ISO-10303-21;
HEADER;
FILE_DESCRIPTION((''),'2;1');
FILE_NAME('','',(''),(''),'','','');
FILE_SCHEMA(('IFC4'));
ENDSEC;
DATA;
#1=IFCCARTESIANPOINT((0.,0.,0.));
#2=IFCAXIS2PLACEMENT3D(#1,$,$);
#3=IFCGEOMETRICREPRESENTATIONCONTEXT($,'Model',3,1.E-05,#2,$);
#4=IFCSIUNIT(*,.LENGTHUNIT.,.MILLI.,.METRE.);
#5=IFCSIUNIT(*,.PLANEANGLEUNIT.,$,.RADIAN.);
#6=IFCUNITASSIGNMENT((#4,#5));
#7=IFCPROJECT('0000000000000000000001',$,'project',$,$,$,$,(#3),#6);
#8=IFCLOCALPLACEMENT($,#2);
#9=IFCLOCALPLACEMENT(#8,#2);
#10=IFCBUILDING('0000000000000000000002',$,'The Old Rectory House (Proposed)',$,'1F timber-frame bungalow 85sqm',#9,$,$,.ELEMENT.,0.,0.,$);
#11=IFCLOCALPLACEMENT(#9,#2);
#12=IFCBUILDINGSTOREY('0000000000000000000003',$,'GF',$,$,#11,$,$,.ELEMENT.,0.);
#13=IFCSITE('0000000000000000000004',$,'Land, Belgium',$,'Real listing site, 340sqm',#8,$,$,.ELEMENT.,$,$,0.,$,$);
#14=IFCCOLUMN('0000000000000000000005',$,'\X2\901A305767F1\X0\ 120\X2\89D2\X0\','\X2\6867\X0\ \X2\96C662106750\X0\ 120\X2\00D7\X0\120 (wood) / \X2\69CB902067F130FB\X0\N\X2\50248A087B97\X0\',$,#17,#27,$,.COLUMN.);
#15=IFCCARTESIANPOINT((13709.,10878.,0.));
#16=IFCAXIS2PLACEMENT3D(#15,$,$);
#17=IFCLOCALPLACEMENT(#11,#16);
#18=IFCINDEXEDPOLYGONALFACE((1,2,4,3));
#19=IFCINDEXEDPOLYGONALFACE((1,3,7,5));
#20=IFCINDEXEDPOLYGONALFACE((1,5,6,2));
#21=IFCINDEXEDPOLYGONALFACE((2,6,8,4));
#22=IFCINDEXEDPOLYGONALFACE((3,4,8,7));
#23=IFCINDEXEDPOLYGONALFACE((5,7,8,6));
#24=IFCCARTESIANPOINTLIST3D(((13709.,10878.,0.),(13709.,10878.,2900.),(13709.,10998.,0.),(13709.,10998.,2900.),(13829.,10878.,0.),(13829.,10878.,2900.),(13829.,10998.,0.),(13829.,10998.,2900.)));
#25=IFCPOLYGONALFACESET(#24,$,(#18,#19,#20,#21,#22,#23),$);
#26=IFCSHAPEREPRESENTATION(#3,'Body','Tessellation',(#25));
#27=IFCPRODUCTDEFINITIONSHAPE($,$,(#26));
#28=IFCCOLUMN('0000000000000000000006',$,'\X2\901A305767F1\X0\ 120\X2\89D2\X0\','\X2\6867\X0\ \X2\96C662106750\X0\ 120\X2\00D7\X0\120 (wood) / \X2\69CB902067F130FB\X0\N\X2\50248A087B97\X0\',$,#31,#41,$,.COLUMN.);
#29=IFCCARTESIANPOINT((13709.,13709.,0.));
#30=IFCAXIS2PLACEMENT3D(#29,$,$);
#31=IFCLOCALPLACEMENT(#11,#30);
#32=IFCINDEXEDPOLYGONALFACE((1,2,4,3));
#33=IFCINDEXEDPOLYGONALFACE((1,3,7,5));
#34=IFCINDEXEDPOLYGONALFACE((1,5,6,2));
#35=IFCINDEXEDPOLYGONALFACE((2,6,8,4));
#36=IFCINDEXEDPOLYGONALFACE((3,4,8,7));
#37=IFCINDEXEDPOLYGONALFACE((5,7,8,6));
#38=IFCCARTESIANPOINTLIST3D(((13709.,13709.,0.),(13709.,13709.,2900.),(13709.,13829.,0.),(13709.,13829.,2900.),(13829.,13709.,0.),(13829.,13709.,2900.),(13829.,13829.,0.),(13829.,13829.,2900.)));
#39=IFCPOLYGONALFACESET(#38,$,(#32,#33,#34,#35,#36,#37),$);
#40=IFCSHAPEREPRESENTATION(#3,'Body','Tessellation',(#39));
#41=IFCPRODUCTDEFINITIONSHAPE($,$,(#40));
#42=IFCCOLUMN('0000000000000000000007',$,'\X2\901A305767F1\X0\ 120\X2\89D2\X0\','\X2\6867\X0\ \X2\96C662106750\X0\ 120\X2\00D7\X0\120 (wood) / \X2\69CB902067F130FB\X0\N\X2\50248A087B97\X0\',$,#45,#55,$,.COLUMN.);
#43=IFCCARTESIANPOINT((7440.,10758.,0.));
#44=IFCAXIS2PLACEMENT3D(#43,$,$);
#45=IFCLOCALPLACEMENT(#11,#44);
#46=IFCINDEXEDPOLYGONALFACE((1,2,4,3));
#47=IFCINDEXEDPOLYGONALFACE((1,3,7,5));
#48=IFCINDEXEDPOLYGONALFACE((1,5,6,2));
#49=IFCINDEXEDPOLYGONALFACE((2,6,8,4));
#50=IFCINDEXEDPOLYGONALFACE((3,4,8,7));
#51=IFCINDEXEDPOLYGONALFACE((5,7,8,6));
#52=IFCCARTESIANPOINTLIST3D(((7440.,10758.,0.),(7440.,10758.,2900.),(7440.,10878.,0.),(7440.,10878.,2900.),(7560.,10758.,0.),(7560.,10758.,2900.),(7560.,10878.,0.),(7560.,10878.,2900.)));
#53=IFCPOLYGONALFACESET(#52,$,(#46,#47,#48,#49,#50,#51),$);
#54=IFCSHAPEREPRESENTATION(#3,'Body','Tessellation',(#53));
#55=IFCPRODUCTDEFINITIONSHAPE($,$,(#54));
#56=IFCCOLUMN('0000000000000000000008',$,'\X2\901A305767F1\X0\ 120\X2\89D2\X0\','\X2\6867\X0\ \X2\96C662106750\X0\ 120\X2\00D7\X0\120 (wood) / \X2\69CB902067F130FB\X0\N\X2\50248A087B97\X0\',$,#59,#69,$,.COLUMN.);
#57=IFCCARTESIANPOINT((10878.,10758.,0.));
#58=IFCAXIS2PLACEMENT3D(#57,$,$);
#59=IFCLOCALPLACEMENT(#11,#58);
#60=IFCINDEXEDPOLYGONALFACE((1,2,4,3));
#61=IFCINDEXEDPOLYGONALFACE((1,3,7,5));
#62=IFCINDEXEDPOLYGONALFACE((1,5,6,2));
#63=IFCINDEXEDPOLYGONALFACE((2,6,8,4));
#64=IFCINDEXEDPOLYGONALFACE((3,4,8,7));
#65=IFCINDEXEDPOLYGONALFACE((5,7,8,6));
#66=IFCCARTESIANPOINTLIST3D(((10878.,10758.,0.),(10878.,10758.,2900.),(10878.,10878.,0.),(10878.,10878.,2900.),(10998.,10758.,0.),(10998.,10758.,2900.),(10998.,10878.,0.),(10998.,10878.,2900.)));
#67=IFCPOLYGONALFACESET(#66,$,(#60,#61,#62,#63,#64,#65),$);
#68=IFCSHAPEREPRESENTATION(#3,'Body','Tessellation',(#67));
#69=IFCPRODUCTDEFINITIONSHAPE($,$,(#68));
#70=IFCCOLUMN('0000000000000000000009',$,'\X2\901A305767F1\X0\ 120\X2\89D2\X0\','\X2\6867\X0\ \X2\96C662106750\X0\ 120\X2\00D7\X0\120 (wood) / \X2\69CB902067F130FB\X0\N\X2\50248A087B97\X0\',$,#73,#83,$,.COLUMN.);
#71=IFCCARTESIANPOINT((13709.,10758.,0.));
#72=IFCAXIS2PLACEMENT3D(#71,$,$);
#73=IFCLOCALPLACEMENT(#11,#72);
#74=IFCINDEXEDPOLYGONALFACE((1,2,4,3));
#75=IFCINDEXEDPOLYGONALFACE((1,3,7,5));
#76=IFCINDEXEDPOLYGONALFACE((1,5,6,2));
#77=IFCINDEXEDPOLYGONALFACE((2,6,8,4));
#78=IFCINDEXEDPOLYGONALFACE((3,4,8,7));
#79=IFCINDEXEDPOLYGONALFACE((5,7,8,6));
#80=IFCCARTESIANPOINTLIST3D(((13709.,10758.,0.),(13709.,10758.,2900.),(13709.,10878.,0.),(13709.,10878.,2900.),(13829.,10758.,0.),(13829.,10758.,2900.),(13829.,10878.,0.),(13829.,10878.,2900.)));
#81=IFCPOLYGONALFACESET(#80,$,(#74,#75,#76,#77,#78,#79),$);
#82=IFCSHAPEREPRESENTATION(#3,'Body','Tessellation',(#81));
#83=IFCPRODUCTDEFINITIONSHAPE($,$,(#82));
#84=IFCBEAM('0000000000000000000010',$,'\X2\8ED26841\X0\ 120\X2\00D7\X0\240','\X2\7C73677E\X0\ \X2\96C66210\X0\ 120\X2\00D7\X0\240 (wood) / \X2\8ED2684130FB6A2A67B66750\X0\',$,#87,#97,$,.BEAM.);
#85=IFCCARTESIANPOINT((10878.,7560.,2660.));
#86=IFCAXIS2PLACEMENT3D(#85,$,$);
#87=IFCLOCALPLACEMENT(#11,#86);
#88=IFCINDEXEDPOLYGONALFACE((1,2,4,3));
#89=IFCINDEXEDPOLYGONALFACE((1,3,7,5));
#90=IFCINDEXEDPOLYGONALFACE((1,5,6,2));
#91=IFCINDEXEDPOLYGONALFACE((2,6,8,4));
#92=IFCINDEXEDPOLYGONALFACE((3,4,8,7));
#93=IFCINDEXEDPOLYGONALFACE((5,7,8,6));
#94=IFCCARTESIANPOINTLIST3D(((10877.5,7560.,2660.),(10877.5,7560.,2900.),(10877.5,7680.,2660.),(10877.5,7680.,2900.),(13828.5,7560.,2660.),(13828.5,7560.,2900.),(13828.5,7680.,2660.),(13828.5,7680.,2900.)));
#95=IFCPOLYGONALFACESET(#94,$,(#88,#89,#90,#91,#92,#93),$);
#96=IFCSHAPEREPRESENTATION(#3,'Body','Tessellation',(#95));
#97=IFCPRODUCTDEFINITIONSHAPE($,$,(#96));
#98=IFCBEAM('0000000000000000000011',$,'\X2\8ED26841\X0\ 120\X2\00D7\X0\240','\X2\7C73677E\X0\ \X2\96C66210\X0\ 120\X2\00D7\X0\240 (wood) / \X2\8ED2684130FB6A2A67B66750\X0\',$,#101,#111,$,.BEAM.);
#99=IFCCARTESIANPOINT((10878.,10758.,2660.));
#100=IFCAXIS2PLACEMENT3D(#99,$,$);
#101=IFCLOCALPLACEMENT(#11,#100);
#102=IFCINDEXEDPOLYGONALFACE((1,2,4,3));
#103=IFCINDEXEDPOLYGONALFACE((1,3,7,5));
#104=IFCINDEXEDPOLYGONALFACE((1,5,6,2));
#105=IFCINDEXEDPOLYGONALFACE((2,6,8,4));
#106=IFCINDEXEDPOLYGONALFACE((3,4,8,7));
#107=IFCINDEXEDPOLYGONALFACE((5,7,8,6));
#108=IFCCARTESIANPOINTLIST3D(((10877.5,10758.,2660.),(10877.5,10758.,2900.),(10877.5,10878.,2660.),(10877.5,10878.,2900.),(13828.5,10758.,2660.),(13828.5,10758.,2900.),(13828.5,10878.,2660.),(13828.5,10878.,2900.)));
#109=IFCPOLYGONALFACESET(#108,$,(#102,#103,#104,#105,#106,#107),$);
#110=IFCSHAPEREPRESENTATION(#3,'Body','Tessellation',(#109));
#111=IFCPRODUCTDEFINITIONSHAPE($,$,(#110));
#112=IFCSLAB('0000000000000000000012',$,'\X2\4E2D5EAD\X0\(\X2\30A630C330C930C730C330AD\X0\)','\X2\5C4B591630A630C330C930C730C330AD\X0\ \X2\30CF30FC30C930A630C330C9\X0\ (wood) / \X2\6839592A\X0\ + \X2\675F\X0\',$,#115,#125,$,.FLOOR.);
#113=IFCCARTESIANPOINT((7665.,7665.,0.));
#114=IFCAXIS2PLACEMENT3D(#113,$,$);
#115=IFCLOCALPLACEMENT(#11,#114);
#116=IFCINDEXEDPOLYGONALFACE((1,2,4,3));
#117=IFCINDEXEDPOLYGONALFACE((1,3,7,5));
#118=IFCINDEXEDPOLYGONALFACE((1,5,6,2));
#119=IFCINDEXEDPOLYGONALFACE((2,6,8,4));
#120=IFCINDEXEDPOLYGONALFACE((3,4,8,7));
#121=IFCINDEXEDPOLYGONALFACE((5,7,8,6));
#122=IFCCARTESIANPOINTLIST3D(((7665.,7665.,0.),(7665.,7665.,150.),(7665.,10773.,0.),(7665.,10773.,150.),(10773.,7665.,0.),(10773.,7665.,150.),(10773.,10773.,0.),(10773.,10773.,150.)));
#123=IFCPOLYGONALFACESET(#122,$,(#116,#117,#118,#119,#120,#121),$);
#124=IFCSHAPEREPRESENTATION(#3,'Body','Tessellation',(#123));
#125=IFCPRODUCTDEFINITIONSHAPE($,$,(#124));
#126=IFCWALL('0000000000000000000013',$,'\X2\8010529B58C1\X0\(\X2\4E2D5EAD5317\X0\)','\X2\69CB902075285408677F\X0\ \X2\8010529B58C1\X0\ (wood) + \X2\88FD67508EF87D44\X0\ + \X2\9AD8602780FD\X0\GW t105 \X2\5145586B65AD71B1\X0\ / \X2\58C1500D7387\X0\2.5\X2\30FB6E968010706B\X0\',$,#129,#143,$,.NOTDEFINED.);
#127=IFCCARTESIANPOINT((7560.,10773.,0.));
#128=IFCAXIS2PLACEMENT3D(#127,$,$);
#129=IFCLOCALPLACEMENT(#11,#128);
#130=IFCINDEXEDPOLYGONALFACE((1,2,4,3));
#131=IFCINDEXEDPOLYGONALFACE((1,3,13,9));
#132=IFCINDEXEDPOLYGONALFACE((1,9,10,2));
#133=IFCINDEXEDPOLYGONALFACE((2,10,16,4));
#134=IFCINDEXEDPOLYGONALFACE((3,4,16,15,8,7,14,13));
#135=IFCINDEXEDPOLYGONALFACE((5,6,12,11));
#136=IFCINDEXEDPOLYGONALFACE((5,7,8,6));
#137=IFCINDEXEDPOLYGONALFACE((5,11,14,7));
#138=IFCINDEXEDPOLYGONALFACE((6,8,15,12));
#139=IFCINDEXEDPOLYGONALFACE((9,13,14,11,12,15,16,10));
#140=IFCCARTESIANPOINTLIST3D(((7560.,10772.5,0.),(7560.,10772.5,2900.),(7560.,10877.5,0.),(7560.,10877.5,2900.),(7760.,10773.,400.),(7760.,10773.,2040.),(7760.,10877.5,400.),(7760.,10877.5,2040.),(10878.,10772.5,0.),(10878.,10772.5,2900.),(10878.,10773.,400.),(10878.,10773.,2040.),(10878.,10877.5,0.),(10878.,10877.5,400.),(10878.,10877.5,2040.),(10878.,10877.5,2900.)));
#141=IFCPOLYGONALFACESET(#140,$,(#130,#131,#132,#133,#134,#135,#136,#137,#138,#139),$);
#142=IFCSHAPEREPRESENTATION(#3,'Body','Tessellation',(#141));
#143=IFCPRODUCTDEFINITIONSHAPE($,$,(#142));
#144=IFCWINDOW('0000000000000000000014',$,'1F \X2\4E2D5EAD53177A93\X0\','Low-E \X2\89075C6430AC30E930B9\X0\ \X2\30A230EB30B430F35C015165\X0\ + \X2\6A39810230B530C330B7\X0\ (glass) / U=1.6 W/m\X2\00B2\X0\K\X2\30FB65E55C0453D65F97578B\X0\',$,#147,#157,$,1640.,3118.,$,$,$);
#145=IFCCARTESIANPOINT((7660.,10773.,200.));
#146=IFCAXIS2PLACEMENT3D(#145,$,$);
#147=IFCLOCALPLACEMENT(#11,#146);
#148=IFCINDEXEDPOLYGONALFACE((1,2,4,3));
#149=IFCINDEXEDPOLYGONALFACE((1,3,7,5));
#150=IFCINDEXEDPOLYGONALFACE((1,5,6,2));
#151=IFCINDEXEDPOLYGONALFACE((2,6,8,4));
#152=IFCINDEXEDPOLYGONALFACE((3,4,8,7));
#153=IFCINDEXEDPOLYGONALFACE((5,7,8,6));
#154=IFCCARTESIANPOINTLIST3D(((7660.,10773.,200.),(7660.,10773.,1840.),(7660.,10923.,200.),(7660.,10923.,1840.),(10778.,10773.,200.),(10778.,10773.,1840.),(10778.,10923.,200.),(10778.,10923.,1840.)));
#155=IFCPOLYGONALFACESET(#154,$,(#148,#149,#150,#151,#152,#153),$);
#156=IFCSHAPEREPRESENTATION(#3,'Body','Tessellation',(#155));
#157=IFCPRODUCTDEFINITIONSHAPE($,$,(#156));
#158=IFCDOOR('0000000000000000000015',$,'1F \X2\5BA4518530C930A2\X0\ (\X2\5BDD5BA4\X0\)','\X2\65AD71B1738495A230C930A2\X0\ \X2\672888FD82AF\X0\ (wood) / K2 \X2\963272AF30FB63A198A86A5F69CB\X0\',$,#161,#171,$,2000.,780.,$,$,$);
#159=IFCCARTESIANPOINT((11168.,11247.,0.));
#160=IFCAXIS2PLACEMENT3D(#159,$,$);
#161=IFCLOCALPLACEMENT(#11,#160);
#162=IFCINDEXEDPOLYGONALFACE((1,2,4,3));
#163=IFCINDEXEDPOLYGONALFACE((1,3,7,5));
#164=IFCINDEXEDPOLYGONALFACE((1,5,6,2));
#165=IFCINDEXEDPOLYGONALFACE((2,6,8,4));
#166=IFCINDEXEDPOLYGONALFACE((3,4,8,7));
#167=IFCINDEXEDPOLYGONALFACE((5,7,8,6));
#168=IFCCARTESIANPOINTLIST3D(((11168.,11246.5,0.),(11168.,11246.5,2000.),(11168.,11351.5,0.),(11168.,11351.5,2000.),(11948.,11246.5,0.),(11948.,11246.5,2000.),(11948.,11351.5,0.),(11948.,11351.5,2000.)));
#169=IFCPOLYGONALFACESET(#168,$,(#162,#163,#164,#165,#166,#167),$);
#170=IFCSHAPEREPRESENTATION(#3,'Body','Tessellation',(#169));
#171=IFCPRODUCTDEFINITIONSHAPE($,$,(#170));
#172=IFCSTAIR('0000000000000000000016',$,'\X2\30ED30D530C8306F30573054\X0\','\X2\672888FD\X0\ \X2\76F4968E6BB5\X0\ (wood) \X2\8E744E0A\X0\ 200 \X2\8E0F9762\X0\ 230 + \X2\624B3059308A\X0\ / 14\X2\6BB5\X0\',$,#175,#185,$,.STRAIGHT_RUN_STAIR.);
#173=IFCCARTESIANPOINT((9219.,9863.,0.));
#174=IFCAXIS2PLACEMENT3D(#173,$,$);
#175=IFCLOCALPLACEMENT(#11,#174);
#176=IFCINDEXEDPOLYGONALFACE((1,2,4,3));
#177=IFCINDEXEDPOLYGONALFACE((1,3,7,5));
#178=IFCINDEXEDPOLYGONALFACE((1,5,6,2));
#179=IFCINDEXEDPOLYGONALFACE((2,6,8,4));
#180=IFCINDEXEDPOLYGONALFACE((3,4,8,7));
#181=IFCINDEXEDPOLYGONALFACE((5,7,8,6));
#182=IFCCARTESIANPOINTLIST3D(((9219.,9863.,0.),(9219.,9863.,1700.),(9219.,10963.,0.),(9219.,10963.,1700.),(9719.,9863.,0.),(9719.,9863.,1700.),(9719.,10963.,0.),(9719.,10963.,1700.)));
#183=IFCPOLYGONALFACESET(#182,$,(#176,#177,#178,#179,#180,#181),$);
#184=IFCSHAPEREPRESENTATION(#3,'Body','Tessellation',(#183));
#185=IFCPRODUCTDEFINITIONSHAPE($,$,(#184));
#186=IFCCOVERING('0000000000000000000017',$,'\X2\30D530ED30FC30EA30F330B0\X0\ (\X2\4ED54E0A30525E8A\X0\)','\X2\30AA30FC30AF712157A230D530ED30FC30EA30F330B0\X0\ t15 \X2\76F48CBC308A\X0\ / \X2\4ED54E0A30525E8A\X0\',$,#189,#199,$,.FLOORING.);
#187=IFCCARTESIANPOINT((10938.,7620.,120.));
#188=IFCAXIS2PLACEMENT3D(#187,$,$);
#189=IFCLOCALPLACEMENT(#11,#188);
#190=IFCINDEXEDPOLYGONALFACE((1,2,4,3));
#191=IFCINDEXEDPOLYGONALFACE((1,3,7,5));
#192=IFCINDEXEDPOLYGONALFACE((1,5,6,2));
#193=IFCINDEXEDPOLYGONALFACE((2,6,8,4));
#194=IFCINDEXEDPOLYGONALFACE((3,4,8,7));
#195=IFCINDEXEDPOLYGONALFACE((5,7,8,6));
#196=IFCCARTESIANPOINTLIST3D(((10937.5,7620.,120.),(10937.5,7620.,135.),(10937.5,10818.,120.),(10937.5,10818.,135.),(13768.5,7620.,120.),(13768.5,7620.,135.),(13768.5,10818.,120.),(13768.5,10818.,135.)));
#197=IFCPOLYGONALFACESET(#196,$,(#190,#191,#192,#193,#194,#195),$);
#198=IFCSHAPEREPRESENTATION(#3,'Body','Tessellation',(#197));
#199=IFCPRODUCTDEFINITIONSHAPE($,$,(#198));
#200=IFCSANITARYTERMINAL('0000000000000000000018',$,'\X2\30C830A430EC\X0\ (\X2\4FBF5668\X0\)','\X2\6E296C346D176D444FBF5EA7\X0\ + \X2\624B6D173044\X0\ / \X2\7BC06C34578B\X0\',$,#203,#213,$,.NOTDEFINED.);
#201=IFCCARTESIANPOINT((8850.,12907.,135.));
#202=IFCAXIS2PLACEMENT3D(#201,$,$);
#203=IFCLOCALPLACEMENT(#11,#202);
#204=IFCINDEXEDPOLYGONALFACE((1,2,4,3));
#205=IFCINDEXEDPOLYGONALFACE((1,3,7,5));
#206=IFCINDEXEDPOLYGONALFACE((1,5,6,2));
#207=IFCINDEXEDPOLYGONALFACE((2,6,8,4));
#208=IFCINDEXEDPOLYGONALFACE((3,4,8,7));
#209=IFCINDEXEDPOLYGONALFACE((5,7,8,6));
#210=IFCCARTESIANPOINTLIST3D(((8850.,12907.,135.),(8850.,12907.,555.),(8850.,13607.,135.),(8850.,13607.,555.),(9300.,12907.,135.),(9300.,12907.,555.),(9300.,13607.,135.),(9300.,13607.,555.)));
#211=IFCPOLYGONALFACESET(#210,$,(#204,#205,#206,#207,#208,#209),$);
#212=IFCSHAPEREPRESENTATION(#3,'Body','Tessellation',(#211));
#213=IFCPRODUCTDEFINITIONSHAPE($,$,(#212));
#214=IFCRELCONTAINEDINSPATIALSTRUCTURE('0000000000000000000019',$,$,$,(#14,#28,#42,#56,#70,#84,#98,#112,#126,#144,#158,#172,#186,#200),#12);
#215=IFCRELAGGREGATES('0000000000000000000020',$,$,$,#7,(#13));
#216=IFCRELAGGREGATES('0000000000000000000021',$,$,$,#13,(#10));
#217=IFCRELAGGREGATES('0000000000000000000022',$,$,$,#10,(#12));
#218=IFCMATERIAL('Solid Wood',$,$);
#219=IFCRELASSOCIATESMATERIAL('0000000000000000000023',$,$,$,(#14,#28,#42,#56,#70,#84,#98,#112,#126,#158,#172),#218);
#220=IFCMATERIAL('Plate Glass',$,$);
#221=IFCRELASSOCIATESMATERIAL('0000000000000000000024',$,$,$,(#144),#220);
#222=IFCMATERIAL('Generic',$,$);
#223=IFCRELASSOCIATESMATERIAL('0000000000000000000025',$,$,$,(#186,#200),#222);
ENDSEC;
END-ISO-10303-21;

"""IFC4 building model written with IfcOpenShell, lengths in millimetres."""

from ifc_helpers import new_model, si_unit, frame, frame_2d, origin, place, context, project, spatial, rectangle, extrude, material, element, fill, save


model = new_model("IFC4")

# Units and contexts
model_context = context("Model", 3, precision=1e-05, world=origin())
ifc_project = project(units=[si_unit("LENGTHUNIT", "METRE", prefix="MILLI"), si_unit("PLANEANGLEUNIT", "RADIAN")], contexts=[model_context])

# Site, building, storey
site_placement = place(None, origin())
site = spatial("IfcSite", under=ifc_project, at=site_placement, Name="Land, Belgium", ObjectType="Real listing site, 340sqm", CompositionType="ELEMENT", RefElevation=0.0)
building_placement = place(site_placement, origin())
building = spatial("IfcBuilding", under=site, at=building_placement, Name="The Old Rectory House (Proposed)", ObjectType="1F timber-frame bungalow 85sqm", CompositionType="ELEMENT", ElevationOfRefHeight=0.0, ElevationOfTerrain=0.0)
storey_placement = place(building_placement, origin())
storey = spatial("IfcBuildingStorey", under=building, at=storey_placement, Name="GF", CompositionType="ELEMENT", Elevation=0.0)

# Columns
ifc_material_1 = material(Name="Solid Wood")
column_1_placement = place(storey_placement, frame((13709.0, 10878.0, 0.0)))
element("IfcColumn", 1, at=column_1_placement, inside=storey, material=ifc_material_1, Name="通し柱 120角", Description="桧 集成材 120×120 (wood) / 構造柱・N値計算", PredefinedType="COLUMN", context=model_context, shape_type="SweptSolid", body=[
    extrude(rectangle(XDim=120.0, YDim=120.0, at=frame_2d((60.0, 60.0))), frame((13709.0, 10878.0, 0.0)), (0.0, 0.0, 1.0), 2900.0),
])
column_2_placement = place(storey_placement, frame((13709.0, 13709.0, 0.0)))
element("IfcColumn", 2, at=column_2_placement, inside=storey, material=ifc_material_1, Name="通し柱 120角", Description="桧 集成材 120×120 (wood) / 構造柱・N値計算", PredefinedType="COLUMN", context=model_context, shape_type="SweptSolid", body=[
    extrude(rectangle(XDim=120.0, YDim=120.0, at=frame_2d((60.0, 60.0))), frame((13709.0, 13709.0, 0.0)), (0.0, 0.0, 1.0), 2900.0),
])
column_3_placement = place(storey_placement, frame((7440.0, 10758.0, 0.0)))
element("IfcColumn", 3, at=column_3_placement, inside=storey, material=ifc_material_1, Name="通し柱 120角", Description="桧 集成材 120×120 (wood) / 構造柱・N値計算", PredefinedType="COLUMN", context=model_context, shape_type="SweptSolid", body=[
    extrude(rectangle(XDim=120.0, YDim=120.0, at=frame_2d((60.0, 60.0))), frame((7440.0, 10758.0, 0.0)), (0.0, 0.0, 1.0), 2900.0),
])
column_4_placement = place(storey_placement, frame((10878.0, 10758.0, 0.0)))
element("IfcColumn", 4, at=column_4_placement, inside=storey, material=ifc_material_1, Name="通し柱 120角", Description="桧 集成材 120×120 (wood) / 構造柱・N値計算", PredefinedType="COLUMN", context=model_context, shape_type="SweptSolid", body=[
    extrude(rectangle(XDim=120.0, YDim=120.0, at=frame_2d((60.0, 60.0))), frame((10878.0, 10758.0, 0.0)), (0.0, 0.0, 1.0), 2900.0),
])
column_5_placement = place(storey_placement, frame((13709.0, 10758.0, 0.0)))
element("IfcColumn", 5, at=column_5_placement, inside=storey, material=ifc_material_1, Name="通し柱 120角", Description="桧 集成材 120×120 (wood) / 構造柱・N値計算", PredefinedType="COLUMN", context=model_context, shape_type="SweptSolid", body=[
    extrude(rectangle(XDim=120.0, YDim=120.0, at=frame_2d((60.0, 60.0))), frame((13709.0, 10758.0, 0.0)), (0.0, 0.0, 1.0), 2900.0),
])

# Beams
beam_1_placement = place(storey_placement, frame((10878.0, 7560.0, 2660.0)))
element("IfcBeam", 6, at=beam_1_placement, inside=storey, material=ifc_material_1, Name="軒桁 120×240", Description="米松 集成 120×240 (wood) / 軒桁・横架材", PredefinedType="BEAM", context=model_context, shape_type="SweptSolid", body=[
    extrude(rectangle(XDim=2951.0, YDim=120.0, at=frame_2d((1475.0, 60.0))), frame((10878.0, 7560.0, 2660.0)), (0.0, 0.0, 1.0), 240.0),
])
beam_2_placement = place(storey_placement, frame((10878.0, 10758.0, 2660.0)))
element("IfcBeam", 7, at=beam_2_placement, inside=storey, material=ifc_material_1, Name="軒桁 120×240", Description="米松 集成 120×240 (wood) / 軒桁・横架材", PredefinedType="BEAM", context=model_context, shape_type="SweptSolid", body=[
    extrude(rectangle(XDim=2951.0, YDim=120.0, at=frame_2d((1475.0, 60.0))), frame((10878.0, 10758.0, 2660.0)), (0.0, 0.0, 1.0), 240.0),
])

# Slab
slab_placement = place(storey_placement, frame((7665.0, 7665.0, 0.0)))
element("IfcSlab", 8, at=slab_placement, inside=storey, material=ifc_material_1, Name="中庭(ウッドデッキ)", Description="屋外ウッドデッキ ハードウッド (wood) / 根太 + 束", PredefinedType="FLOOR", context=model_context, shape_type="SweptSolid", body=[
    extrude(rectangle(XDim=3108.0, YDim=3108.0, at=frame_2d((1554.0, 1554.0))), frame((7665.0, 7665.0, 0.0)), (0.0, 0.0, 1.0), 150.0),
])

# Wall, opening, window
wall_1_placement = place(storey_placement, frame((7560.0, 10773.0, 0.0)))
wall_1 = element("IfcWall", 9, at=wall_1_placement, inside=storey, material=ifc_material_1, Name="耐力壁(中庭北)", Description="構造用合板 耐力壁 (wood) + 製材軸組 + 高性能GW t105 充填断熱 / 壁倍率2.5・準耐火", PredefinedType="NOTDEFINED", context=model_context, shape_type="SweptSolid", body=[
    extrude(rectangle(XDim=3318.0, YDim=105.0, at=frame_2d((1659.0, 52.0))), frame((7560.0, 10773.0, 0.0)), (0.0, 0.0, 1.0), 2900.0),
])
opening_placement = place(storey_placement, frame((7660.0, 10773.0, 200.0)))
opening = element("IfcOpeningElement", 10, at=opening_placement, cuts=wall_1, PredefinedType="NOTDEFINED", context=model_context, shape_type="SweptSolid", body=[
    extrude(rectangle(XDim=3118.0, YDim=150.0, at=frame_2d((1559.0, 75.0))), frame((7660.0, 10773.0, 200.0)), (0.0, 0.0, 1.0), 1640.0),
])
ifc_material_2 = material(Name="Plate Glass")
window_placement = place(storey_placement, frame((7660.0, 10773.0, 200.0)))
window = element("IfcWindow", 11, at=window_placement, inside=storey, material=ifc_material_2, Name="1F 中庭北窓", Description="Low-E 複層ガラス アルゴン封入 + 樹脂サッシ (glass) / U=1.6 W/m²K・日射取得型", OverallHeight=1640.0, OverallWidth=3118.0, context=model_context, shape_type="SweptSolid", body=[
    extrude(rectangle(XDim=3118.0, YDim=150.0, at=frame_2d((1559.0, 75.0))), frame((7660.0, 10773.0, 200.0)), (0.0, 0.0, 1.0), 1640.0),
])
fill(opening, window)

# Door
door_placement = place(storey_placement, frame((11168.0, 11247.0, 0.0)))
element("IfcDoor", 12, at=door_placement, inside=storey, material=ifc_material_1, Name="1F 室内ドア (寝室)", Description="断熱玄関ドア 木製芯 (wood) / K2 防犯・採風機構", OverallHeight=2000.0, OverallWidth=780.0, context=model_context, shape_type="SweptSolid", body=[
    extrude(rectangle(XDim=780.0, YDim=105.0, at=frame_2d((390.0, 52.0))), frame((11168.0, 11247.0, 0.0)), (0.0, 0.0, 1.0), 2000.0),
])

# Stair
stair_placement = place(storey_placement, frame((9219.0, 9863.0, 0.0)))
element("IfcStair", 13, at=stair_placement, inside=storey, material=ifc_material_1, Name="ロフトはしご", Description="木製 直階段 (wood) 蹴上 200 踏面 230 + 手すり / 14段", PredefinedType="STRAIGHT_RUN_STAIR", context=model_context, shape_type="SweptSolid", body=[
    extrude(rectangle(XDim=500.0, YDim=1100.0, at=frame_2d((250.0, 550.0))), frame((9219.0, 9863.0, 0.0)), (0.0, 0.0, 1.0), 1700.0),
])

# Covering
ifc_material_3 = material(Name="Generic")
covering_placement = place(storey_placement, frame((10938.0, 7620.0, 120.0)))
element("IfcCovering", 14, at=covering_placement, inside=storey, material=ifc_material_3, Name="フローリング (仕上げ床)", Description="オーク無垢フローリング t15 直貼り / 仕上げ床", PredefinedType="FLOORING", context=model_context, shape_type="SweptSolid", body=[
    extrude(rectangle(XDim=2831.0, YDim=3198.0, at=frame_2d((1415.0, 1599.0))), frame((10938.0, 7620.0, 120.0)), (0.0, 0.0, 1.0), 15.0),
])

# Sanitary terminal
sanitary_terminal_placement = place(storey_placement, frame((8850.0, 12907.0, 135.0)))
element("IfcSanitaryTerminal", 15, at=sanitary_terminal_placement, inside=storey, material=ifc_material_3, Name="トイレ (便器)", Description="温水洗浄便座 + 手洗い / 節水型", PredefinedType="NOTDEFINED", context=model_context, shape_type="SweptSolid", body=[
    extrude(rectangle(XDim=450.0, YDim=700.0, at=frame_2d((225.0, 350.0))), frame((8850.0, 12907.0, 135.0)), (0.0, 0.0, 1.0), 420.0),
])

save(model, "model.ifc")
